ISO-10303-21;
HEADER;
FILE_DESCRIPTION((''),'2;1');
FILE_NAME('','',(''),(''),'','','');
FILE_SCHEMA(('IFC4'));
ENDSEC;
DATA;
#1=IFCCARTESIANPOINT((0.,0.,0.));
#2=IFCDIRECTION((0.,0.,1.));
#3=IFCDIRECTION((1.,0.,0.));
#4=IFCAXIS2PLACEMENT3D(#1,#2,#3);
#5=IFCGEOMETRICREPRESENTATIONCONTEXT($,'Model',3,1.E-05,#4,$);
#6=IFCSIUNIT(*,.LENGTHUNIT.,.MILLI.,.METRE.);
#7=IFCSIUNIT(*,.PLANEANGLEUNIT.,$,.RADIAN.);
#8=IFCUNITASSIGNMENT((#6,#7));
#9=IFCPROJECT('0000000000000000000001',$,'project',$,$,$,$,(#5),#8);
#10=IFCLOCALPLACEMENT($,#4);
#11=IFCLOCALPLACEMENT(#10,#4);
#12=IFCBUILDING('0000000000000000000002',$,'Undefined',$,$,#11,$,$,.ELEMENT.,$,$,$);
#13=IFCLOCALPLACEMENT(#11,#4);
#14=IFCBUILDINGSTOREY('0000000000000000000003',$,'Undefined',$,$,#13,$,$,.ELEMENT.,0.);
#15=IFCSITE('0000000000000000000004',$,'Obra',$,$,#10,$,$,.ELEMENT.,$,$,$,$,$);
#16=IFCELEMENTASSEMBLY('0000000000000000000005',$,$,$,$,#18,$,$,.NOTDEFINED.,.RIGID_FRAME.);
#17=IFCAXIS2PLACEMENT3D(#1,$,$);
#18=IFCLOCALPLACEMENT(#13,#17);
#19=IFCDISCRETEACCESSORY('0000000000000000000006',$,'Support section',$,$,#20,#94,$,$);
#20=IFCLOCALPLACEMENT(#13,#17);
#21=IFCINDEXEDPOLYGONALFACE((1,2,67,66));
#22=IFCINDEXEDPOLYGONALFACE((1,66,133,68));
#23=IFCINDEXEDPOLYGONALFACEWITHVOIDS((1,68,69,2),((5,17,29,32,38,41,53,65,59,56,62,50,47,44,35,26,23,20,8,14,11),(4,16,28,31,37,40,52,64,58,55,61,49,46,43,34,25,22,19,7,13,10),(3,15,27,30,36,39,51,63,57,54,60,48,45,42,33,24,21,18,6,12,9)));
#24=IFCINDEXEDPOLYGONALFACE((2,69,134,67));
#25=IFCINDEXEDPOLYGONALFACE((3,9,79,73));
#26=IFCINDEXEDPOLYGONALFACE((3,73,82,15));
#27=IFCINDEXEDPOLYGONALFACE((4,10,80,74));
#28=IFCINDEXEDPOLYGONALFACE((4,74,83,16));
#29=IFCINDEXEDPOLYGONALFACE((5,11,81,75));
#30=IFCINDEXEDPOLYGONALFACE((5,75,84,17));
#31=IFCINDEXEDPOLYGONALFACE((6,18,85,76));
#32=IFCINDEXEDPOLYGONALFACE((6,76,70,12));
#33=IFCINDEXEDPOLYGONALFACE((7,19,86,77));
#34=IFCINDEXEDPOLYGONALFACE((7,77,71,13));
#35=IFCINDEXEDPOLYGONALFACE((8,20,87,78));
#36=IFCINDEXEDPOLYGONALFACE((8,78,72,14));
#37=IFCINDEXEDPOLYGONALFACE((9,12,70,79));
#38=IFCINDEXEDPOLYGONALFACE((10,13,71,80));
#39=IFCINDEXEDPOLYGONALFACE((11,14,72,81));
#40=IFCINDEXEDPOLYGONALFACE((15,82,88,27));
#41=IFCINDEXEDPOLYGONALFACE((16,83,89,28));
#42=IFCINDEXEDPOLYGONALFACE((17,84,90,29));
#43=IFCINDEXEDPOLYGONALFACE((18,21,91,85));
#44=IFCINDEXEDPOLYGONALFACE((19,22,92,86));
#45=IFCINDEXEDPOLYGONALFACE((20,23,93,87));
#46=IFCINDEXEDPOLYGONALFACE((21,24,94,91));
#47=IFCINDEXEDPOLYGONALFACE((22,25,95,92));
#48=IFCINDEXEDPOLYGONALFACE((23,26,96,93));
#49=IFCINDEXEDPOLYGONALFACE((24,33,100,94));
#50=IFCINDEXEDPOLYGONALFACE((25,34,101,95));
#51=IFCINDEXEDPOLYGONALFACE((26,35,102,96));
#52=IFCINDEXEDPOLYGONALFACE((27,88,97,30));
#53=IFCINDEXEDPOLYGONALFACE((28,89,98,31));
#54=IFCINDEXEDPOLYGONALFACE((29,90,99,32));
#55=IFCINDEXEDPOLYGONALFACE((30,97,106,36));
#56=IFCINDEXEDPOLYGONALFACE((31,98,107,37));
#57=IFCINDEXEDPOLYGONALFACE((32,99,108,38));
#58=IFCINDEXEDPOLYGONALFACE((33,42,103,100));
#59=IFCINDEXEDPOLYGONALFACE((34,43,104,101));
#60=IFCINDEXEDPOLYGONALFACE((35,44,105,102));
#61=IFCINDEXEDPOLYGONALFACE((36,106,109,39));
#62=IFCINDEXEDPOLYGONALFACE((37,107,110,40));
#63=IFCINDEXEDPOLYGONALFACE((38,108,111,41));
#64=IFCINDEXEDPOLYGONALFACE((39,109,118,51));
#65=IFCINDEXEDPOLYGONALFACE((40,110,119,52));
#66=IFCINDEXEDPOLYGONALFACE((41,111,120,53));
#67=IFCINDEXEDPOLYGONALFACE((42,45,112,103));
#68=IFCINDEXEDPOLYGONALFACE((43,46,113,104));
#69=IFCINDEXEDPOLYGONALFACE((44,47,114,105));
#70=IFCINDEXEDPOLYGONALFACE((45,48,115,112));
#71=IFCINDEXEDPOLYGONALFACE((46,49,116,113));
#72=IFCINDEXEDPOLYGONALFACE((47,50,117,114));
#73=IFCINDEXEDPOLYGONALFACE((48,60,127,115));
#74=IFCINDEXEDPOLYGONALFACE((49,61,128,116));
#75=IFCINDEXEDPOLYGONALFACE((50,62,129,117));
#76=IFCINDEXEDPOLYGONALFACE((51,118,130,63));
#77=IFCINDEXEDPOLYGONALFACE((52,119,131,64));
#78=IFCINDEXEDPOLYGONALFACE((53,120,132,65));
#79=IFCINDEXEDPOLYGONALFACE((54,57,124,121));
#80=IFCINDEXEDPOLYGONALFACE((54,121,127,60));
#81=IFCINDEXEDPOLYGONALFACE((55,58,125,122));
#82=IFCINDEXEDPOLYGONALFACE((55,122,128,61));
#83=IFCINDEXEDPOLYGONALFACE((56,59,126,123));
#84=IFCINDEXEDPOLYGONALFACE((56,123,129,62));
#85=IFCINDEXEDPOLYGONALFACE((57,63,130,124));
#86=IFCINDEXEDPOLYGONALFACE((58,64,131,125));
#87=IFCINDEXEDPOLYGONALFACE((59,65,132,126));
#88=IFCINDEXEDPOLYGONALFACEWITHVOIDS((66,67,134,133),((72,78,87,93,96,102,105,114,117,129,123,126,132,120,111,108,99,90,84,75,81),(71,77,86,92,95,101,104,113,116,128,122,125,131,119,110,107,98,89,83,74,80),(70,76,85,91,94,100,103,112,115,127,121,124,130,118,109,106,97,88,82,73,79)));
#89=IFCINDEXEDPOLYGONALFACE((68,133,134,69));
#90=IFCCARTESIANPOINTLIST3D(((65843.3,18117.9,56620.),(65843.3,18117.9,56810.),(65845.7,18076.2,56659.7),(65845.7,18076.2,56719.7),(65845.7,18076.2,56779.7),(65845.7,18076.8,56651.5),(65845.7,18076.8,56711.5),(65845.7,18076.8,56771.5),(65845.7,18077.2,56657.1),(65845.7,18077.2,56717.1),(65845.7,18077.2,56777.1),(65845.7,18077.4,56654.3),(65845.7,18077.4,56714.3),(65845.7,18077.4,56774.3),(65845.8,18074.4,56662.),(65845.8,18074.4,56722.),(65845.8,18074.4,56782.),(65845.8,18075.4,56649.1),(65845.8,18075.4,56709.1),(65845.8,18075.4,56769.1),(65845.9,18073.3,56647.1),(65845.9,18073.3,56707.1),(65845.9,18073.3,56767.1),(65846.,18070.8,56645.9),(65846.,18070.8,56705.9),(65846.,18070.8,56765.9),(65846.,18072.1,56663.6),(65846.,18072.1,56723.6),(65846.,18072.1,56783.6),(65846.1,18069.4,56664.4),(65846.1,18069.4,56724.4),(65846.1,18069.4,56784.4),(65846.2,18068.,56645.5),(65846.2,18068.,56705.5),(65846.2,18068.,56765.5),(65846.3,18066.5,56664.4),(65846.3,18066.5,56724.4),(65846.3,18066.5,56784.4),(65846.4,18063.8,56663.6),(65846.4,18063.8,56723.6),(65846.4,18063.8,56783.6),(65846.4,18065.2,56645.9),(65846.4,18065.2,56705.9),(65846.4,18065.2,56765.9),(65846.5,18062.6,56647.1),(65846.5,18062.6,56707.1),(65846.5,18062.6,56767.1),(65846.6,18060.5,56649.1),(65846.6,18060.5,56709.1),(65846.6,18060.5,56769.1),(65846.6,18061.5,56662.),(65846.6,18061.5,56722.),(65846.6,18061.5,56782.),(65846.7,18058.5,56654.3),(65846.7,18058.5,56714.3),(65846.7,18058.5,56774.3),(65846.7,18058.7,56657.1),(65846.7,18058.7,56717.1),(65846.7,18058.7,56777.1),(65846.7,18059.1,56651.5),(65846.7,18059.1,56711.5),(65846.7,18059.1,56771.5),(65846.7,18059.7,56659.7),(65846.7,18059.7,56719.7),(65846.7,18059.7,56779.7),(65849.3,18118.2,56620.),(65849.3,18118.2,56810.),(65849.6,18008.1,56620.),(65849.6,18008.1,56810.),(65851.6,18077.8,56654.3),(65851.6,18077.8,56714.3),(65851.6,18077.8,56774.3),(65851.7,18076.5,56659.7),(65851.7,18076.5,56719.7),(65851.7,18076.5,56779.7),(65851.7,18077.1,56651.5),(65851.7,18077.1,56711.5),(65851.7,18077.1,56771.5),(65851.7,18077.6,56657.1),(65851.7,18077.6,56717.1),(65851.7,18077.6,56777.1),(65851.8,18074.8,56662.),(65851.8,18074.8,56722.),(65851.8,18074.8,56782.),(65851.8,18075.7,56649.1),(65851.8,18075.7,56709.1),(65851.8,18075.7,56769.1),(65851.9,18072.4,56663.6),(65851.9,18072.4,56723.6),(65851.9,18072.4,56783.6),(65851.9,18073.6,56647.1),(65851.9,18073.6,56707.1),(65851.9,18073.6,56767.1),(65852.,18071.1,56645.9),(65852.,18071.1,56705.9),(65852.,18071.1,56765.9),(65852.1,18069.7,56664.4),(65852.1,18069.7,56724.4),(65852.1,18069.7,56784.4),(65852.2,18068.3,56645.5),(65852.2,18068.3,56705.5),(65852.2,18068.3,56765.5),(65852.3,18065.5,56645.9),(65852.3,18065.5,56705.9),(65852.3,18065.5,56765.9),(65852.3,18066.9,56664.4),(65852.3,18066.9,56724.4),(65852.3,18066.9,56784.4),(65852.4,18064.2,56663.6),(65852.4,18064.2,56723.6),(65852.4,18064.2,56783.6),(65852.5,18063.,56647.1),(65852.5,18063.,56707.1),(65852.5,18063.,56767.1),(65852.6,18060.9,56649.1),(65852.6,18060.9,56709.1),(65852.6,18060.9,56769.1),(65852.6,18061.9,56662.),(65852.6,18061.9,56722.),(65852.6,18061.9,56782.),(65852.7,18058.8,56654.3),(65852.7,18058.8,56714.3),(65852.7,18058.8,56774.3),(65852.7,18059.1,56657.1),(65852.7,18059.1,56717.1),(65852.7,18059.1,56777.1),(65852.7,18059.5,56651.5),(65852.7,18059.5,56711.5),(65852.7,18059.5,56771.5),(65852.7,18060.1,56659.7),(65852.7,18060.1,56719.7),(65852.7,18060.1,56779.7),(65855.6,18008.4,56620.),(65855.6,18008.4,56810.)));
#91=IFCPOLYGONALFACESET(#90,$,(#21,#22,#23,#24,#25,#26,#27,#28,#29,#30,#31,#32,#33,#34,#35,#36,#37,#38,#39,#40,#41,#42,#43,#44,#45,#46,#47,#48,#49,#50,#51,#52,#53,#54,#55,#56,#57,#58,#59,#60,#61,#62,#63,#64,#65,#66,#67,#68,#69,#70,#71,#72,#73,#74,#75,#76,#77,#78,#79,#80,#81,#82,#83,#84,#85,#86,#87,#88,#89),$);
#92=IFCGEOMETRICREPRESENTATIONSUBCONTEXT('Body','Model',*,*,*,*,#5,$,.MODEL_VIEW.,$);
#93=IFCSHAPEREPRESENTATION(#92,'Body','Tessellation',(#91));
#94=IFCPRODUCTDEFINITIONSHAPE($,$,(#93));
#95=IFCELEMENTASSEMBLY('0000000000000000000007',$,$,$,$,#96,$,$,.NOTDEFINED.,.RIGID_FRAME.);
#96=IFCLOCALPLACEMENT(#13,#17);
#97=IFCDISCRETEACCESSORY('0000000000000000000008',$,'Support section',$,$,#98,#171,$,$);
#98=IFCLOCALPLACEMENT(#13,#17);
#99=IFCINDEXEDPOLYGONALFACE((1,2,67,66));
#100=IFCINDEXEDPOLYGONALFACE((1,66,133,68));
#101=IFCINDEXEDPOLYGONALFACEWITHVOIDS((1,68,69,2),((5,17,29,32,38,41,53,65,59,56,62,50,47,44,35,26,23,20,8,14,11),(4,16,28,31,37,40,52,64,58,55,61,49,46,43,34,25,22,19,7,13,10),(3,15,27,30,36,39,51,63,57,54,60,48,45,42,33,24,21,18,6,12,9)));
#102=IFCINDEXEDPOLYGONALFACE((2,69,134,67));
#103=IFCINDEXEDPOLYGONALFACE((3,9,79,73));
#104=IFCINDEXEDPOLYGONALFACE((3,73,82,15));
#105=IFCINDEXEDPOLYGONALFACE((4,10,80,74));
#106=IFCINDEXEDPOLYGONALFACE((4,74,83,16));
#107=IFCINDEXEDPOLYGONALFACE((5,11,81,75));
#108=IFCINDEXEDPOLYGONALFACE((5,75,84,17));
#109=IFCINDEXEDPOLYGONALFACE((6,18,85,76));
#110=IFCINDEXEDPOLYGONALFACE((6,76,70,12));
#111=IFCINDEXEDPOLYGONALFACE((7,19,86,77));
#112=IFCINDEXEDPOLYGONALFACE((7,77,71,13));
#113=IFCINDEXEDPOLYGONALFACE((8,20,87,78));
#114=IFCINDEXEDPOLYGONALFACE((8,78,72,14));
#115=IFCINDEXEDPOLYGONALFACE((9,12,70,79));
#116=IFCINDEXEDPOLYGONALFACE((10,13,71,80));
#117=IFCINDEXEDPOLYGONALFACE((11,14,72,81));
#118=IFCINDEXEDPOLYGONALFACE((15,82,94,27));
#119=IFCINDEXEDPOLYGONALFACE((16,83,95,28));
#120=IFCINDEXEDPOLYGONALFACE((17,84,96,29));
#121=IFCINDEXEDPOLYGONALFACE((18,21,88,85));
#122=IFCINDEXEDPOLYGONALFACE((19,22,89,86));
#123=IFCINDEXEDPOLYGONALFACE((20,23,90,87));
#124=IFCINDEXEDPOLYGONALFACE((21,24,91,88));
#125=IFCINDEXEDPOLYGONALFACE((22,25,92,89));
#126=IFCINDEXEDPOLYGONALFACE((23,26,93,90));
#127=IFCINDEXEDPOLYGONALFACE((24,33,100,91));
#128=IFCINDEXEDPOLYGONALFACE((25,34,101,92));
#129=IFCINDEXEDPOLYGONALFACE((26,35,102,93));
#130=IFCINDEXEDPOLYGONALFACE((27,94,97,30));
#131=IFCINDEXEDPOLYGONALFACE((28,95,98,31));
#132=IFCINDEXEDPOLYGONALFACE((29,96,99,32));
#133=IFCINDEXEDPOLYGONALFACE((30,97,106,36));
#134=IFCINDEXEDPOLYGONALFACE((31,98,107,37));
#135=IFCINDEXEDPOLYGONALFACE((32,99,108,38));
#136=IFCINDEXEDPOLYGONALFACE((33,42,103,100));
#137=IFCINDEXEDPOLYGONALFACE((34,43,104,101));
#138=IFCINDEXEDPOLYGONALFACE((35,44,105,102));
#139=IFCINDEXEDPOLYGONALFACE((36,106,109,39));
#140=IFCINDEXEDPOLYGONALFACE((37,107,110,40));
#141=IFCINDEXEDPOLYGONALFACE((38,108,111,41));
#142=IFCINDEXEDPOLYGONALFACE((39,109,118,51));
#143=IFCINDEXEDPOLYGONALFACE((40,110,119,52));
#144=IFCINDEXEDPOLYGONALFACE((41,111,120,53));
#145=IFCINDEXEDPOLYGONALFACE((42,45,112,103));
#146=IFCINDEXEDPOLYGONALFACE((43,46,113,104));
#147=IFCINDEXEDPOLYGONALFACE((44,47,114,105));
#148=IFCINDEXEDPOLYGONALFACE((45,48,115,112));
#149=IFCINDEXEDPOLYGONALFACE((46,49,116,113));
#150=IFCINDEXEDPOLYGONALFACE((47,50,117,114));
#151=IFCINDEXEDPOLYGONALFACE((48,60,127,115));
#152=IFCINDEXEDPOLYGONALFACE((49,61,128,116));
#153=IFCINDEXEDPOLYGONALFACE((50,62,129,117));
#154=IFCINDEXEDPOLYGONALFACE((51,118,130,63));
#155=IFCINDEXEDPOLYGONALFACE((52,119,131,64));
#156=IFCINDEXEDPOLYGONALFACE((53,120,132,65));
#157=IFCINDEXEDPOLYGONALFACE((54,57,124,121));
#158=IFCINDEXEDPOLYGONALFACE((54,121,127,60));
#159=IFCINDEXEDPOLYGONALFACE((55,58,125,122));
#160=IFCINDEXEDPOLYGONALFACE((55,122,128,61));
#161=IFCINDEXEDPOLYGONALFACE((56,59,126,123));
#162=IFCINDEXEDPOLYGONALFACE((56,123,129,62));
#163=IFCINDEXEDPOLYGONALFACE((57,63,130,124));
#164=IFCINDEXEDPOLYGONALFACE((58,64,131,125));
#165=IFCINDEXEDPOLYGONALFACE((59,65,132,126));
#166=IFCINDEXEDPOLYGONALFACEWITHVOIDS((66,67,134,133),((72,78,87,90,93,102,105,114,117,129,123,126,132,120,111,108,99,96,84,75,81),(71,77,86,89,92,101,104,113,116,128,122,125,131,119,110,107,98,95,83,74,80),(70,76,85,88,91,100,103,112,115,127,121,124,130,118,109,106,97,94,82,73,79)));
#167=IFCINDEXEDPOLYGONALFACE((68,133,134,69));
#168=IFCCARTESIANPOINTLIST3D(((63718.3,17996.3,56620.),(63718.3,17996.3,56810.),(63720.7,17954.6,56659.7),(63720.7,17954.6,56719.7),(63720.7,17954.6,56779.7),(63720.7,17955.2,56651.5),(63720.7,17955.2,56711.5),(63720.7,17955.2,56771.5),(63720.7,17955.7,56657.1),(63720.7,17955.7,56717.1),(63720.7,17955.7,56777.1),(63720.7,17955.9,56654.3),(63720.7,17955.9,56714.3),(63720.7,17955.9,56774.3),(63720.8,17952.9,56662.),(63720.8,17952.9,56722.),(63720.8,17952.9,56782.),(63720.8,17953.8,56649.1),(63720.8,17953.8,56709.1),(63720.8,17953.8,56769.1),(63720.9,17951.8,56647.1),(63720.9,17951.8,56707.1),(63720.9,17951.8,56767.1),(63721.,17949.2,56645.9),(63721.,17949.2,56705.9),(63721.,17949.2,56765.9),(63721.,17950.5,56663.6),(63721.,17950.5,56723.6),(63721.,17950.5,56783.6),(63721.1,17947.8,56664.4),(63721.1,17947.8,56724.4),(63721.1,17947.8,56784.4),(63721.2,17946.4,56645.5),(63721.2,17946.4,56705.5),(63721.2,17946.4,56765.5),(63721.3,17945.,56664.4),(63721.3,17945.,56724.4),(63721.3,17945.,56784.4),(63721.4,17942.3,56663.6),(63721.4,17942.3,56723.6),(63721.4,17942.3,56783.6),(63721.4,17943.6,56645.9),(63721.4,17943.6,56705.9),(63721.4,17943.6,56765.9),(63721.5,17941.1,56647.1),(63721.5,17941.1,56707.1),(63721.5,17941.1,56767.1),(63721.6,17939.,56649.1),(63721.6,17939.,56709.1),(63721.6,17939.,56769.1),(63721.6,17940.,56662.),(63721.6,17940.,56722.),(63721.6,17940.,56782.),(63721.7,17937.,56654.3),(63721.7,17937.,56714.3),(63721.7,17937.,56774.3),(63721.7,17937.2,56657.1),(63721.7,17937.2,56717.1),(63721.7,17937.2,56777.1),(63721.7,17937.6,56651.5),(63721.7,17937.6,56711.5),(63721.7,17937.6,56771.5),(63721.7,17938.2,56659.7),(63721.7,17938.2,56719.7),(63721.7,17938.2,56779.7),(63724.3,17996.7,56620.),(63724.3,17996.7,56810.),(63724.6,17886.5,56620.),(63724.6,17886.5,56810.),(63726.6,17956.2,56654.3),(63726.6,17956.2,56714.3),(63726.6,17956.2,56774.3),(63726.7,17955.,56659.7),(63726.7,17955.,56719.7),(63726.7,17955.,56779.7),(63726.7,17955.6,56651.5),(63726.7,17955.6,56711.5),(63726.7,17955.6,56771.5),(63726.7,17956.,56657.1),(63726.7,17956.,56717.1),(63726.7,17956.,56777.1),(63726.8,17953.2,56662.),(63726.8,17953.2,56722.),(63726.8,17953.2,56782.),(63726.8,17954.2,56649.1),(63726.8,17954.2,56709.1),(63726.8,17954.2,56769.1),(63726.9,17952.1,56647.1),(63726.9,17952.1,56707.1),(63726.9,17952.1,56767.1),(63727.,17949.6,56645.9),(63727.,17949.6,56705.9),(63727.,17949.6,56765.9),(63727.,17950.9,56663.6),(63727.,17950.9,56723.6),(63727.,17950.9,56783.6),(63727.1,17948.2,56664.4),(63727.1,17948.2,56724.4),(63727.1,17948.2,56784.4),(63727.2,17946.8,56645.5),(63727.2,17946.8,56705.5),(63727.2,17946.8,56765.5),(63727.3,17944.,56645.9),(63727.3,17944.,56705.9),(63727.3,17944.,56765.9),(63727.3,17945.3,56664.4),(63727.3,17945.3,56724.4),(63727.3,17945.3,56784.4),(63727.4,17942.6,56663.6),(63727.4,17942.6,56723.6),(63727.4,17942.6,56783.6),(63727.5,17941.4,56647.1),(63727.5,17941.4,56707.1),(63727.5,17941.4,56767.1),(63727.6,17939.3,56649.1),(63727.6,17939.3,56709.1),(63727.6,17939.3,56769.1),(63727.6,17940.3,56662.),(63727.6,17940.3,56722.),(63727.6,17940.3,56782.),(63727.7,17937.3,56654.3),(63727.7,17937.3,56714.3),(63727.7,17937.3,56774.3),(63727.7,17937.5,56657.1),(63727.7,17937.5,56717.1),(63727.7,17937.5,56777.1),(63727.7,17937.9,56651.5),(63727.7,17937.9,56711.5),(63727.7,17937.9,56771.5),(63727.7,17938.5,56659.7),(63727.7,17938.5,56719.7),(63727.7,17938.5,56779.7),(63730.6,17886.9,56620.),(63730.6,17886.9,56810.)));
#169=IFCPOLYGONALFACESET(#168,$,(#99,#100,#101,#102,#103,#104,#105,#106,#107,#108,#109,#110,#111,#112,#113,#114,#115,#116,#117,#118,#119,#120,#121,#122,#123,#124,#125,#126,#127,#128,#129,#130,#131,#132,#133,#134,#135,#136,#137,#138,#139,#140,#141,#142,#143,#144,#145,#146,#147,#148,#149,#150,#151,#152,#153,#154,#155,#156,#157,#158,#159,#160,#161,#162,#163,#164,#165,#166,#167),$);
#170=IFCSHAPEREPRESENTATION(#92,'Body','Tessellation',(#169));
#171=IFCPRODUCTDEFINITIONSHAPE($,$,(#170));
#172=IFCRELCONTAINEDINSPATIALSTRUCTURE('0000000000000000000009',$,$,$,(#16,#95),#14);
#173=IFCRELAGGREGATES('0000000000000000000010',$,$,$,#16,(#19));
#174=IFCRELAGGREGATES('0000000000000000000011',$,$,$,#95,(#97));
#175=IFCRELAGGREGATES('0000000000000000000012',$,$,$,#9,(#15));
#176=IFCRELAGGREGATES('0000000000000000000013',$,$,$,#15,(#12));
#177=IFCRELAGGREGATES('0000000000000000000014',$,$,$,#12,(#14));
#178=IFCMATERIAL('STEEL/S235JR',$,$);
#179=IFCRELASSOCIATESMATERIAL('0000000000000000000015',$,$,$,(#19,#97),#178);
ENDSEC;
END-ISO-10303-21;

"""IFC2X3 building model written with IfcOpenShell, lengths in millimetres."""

from ifc_helpers import new_model, si_unit, frame, origin_with_axes, origin_2d_with_axis, place, context, subcontext, project, spatial, rectangle, circle, extrude, source, transform, mapped, material, element, aggregate, save


model = new_model("IFC2X3")

# Units and contexts
model_context = context("Model", 3, precision=1e-05, world=origin_with_axes())
body_context = subcontext(model_context, "Body", "Model", "MODEL_VIEW")
ifc_project = project(units=[si_unit("LENGTHUNIT", "METRE", prefix="MILLI"), si_unit("PLANEANGLEUNIT", "RADIAN")], contexts=[model_context])

# Site, building, storey
site_placement = place(None, origin_with_axes())
site = spatial("IfcSite", under=ifc_project, at=site_placement, Name="Obra", CompositionType="ELEMENT")
building_placement = place(site_placement, origin_with_axes())
building = spatial("IfcBuilding", under=site, at=building_placement, Name="Undefined", CompositionType="ELEMENT")
storey_placement = place(building_placement, origin_with_axes())
storey = spatial("IfcBuildingStorey", under=building, at=storey_placement, Name="Undefined", CompositionType="ELEMENT", Elevation=0.0)

# Element assembly
assembly_1_placement = place(storey_placement, origin_with_axes())
assembly_1 = element("IfcElementAssembly", 1, at=assembly_1_placement, inside=storey, AssemblyPlace="NOTDEFINED", PredefinedType="RIGID_FRAME")
ifc_material_1 = material(Name="STEEL/S235JR")

# Discrete accessory, opening
discrete_accessory_1_placement = place(assembly_1_placement, frame((65849.5, 18063.1, 56620.0), z_axis=(0.0, 0.0, 1.0), x_axis=(0.057107, -0.998368, 0.0)))
discrete_accessory_1 = element("IfcDiscreteAccessory", 2, at=discrete_accessory_1_placement, material=ifc_material_1, Name="Support section", context=body_context, shape_type="SweptSolid", body=[
    extrude(rectangle(XDim=6.0, YDim=110.0, at=origin_2d_with_axis()), frame((0.0, 0.0, 190.0), z_axis=(0.0, 0.0, -1.0), x_axis=(0.0, 1.0, 0.0)), (0.0, 0.0, 1.0), 190.0),
])
shared_shape_1 = source(origin_with_axes(), body_context, "Body", "SweptSolid", [
    extrude(circle(Radius=9.5, at=origin_2d_with_axis()), frame((0.0, -9.2, 0.0), z_axis=(0.0, 1.0, 0.0), x_axis=(1.0, 0.0, 0.0)), (0.0, 0.0, 1.0), 6.2),
])
opening_1_placement = place(assembly_1_placement, frame((65846.0, 18017.9, 56835.0), z_axis=(-0.057107, 0.998368, 0.0), x_axis=(0.0, 0.0, -1.0)))
element("IfcOpeningElement", 3, at=opening_1_placement, cuts=discrete_accessory_1, ObjectType="Opening", context=body_context, shape_type="MappedRepresentation", body=[
    mapped(shared_shape_1, transform((60.0, 0.0, 50.0))),
    mapped(shared_shape_1, transform((120.0, 0.0, 50.0))),
    mapped(shared_shape_1, transform((180.0, 0.0, 50.0))),
])
aggregate(assembly_1, [discrete_accessory_1])

# Element assembly, discrete accessory, opening
assembly_2_placement = place(storey_placement, origin_with_axes())
assembly_2 = element("IfcElementAssembly", 4, at=assembly_2_placement, inside=storey, AssemblyPlace="NOTDEFINED", PredefinedType="RIGID_FRAME")
discrete_accessory_2_placement = place(assembly_2_placement, frame((63724.5, 17941.6, 56620.0), z_axis=(0.0, 0.0, 1.0), x_axis=(0.057107, -0.998368, 0.0)))
discrete_accessory_2 = element("IfcDiscreteAccessory", 5, at=discrete_accessory_2_placement, material=ifc_material_1, Name="Support section", context=body_context, shape_type="SweptSolid", body=[
    extrude(rectangle(XDim=6.0, YDim=110.0, at=origin_2d_with_axis()), frame((0.0, 0.0, 190.0), z_axis=(0.0, 0.0, -1.0), x_axis=(0.0, 1.0, 0.0)), (0.0, 0.0, 1.0), 190.0),
])
opening_2_placement = place(assembly_2_placement, frame((63721.0, 17896.3, 56835.0), z_axis=(-0.057107, 0.998368, 0.0), x_axis=(0.0, 0.0, -1.0)))
element("IfcOpeningElement", 6, at=opening_2_placement, cuts=discrete_accessory_2, ObjectType="Opening", context=body_context, shape_type="MappedRepresentation", body=[
    mapped(shared_shape_1, transform((60.0, 0.0, 50.0))),
    mapped(shared_shape_1, transform((120.0, 0.0, 50.0))),
    mapped(shared_shape_1, transform((180.0, 0.0, 50.0))),
])
aggregate(assembly_2, [discrete_accessory_2])

save(model, "model.ifc")
